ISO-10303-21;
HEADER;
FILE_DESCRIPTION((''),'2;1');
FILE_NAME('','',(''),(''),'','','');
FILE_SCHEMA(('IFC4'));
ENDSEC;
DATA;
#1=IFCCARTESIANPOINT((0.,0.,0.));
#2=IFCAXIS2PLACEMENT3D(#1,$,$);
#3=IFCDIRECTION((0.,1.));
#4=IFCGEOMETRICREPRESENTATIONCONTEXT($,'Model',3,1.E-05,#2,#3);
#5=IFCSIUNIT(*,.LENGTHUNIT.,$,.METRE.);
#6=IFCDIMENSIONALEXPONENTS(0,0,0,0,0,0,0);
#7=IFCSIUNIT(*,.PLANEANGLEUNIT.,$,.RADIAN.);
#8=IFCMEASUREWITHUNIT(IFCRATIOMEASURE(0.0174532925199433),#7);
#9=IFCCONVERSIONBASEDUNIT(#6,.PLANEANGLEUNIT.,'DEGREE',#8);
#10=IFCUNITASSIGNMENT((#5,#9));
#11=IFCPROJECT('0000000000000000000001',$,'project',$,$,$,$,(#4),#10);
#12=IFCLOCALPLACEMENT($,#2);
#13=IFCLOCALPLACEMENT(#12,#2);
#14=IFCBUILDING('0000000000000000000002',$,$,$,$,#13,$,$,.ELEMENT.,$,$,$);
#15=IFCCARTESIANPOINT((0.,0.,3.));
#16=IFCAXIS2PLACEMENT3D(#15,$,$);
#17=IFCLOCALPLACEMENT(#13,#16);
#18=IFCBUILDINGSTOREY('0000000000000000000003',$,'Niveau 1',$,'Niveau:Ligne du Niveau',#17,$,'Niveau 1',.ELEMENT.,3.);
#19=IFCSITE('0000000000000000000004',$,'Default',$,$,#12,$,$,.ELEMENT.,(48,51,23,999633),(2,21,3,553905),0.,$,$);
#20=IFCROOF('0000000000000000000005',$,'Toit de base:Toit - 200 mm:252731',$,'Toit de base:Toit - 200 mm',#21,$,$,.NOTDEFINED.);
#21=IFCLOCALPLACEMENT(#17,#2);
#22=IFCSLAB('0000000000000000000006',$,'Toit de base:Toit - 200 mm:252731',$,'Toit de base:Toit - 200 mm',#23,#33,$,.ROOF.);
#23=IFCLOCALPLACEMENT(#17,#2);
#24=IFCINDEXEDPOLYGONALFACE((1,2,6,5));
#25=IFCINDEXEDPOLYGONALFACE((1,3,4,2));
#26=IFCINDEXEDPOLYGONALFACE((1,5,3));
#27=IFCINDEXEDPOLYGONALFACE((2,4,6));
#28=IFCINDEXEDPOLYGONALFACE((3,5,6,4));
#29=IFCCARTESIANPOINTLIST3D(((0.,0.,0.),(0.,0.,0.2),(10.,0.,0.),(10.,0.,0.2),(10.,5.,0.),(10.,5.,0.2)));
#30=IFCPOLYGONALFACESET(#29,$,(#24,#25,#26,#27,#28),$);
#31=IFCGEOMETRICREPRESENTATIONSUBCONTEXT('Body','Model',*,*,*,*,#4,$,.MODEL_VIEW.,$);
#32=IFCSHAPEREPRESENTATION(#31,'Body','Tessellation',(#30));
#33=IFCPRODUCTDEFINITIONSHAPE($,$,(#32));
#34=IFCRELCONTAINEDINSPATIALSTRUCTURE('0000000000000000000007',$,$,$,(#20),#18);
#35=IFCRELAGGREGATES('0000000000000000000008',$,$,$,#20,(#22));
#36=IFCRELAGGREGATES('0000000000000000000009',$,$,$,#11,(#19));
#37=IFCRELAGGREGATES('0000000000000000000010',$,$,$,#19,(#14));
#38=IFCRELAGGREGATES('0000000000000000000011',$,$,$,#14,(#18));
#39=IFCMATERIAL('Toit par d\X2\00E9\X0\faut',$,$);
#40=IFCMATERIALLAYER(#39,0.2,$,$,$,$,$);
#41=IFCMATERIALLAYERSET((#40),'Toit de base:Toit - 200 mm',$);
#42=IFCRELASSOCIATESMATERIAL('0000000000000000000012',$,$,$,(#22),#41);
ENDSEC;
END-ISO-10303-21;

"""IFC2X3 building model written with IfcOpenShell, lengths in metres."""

from ifc_helpers import new_model, entity, si_unit, converted_unit, direction, frame, origin, place, context, subcontext, project, spatial, polyline, outline, extrude, material, layer, layer_set, element, aggregate, save


model = new_model("IFC2X3")

# Units and contexts
model_context = context("Model", 3, precision=1e-05, world=origin(), true_north=direction((0.0, 1.0)))
body_context = subcontext(model_context, "Body", "Model", "MODEL_VIEW")
ifc_project = project(units=[si_unit("LENGTHUNIT", "METRE"), converted_unit("PLANEANGLEUNIT", "DEGREE", entity("IfcRatioMeasure", 0.0174532925199433), si_unit("PLANEANGLEUNIT", "RADIAN"), dimensions=[0, 0, 0, 0, 0, 0, 0])], contexts=[model_context])

# Site, building, storey
site_placement = place(None, origin())
site = spatial("IfcSite", under=ifc_project, at=site_placement, Name="Default", CompositionType="ELEMENT", RefLatitude=(48, 51, 23, 999633), RefLongitude=(2, 21, 3, 553905), RefElevation=0.0)
building_placement = place(site_placement, origin())
building = spatial("IfcBuilding", under=site, at=building_placement, CompositionType="ELEMENT")
storey_placement = place(building_placement, frame((0.0, 0.0, 3.0)))
storey = spatial("IfcBuildingStorey", under=building, at=storey_placement, Name="Niveau 1", ObjectType="Niveau:Ligne du Niveau", LongName="Niveau 1", CompositionType="ELEMENT", Elevation=3.0)

# Roof, slab
roof_placement = place(storey_placement, origin())
roof = element("IfcRoof", 1, at=roof_placement, inside=storey, Name="Toit de base:Toit - 200 mm:252731", ObjectType="Toit de base:Toit - 200 mm", ShapeType="NOTDEFINED")
ifc_material = material(Name="Toit par défaut")
ifc_layer = layer(ifc_material, 0.2)
ifc_layer_set = layer_set([ifc_layer], Name="Toit de base:Toit - 200 mm")
slab_placement = place(roof_placement, origin())
slab = element("IfcSlab", 2, at=slab_placement, material=ifc_layer_set, Name="Toit de base:Toit - 200 mm:252731", ObjectType="Toit de base:Toit - 200 mm", PredefinedType="ROOF", context=body_context, shape_type="SweptSolid", body=[
    extrude(outline(polyline([(5.0, 2.5), (-5.0, -2.5), (5.0, -2.5), (5.0, 2.5)])), frame((5.0, 2.5, 0.0)), (0.0, 0.0, 1.0), 0.2),
])
aggregate(roof, [slab])

save(model, "model.ifc")
